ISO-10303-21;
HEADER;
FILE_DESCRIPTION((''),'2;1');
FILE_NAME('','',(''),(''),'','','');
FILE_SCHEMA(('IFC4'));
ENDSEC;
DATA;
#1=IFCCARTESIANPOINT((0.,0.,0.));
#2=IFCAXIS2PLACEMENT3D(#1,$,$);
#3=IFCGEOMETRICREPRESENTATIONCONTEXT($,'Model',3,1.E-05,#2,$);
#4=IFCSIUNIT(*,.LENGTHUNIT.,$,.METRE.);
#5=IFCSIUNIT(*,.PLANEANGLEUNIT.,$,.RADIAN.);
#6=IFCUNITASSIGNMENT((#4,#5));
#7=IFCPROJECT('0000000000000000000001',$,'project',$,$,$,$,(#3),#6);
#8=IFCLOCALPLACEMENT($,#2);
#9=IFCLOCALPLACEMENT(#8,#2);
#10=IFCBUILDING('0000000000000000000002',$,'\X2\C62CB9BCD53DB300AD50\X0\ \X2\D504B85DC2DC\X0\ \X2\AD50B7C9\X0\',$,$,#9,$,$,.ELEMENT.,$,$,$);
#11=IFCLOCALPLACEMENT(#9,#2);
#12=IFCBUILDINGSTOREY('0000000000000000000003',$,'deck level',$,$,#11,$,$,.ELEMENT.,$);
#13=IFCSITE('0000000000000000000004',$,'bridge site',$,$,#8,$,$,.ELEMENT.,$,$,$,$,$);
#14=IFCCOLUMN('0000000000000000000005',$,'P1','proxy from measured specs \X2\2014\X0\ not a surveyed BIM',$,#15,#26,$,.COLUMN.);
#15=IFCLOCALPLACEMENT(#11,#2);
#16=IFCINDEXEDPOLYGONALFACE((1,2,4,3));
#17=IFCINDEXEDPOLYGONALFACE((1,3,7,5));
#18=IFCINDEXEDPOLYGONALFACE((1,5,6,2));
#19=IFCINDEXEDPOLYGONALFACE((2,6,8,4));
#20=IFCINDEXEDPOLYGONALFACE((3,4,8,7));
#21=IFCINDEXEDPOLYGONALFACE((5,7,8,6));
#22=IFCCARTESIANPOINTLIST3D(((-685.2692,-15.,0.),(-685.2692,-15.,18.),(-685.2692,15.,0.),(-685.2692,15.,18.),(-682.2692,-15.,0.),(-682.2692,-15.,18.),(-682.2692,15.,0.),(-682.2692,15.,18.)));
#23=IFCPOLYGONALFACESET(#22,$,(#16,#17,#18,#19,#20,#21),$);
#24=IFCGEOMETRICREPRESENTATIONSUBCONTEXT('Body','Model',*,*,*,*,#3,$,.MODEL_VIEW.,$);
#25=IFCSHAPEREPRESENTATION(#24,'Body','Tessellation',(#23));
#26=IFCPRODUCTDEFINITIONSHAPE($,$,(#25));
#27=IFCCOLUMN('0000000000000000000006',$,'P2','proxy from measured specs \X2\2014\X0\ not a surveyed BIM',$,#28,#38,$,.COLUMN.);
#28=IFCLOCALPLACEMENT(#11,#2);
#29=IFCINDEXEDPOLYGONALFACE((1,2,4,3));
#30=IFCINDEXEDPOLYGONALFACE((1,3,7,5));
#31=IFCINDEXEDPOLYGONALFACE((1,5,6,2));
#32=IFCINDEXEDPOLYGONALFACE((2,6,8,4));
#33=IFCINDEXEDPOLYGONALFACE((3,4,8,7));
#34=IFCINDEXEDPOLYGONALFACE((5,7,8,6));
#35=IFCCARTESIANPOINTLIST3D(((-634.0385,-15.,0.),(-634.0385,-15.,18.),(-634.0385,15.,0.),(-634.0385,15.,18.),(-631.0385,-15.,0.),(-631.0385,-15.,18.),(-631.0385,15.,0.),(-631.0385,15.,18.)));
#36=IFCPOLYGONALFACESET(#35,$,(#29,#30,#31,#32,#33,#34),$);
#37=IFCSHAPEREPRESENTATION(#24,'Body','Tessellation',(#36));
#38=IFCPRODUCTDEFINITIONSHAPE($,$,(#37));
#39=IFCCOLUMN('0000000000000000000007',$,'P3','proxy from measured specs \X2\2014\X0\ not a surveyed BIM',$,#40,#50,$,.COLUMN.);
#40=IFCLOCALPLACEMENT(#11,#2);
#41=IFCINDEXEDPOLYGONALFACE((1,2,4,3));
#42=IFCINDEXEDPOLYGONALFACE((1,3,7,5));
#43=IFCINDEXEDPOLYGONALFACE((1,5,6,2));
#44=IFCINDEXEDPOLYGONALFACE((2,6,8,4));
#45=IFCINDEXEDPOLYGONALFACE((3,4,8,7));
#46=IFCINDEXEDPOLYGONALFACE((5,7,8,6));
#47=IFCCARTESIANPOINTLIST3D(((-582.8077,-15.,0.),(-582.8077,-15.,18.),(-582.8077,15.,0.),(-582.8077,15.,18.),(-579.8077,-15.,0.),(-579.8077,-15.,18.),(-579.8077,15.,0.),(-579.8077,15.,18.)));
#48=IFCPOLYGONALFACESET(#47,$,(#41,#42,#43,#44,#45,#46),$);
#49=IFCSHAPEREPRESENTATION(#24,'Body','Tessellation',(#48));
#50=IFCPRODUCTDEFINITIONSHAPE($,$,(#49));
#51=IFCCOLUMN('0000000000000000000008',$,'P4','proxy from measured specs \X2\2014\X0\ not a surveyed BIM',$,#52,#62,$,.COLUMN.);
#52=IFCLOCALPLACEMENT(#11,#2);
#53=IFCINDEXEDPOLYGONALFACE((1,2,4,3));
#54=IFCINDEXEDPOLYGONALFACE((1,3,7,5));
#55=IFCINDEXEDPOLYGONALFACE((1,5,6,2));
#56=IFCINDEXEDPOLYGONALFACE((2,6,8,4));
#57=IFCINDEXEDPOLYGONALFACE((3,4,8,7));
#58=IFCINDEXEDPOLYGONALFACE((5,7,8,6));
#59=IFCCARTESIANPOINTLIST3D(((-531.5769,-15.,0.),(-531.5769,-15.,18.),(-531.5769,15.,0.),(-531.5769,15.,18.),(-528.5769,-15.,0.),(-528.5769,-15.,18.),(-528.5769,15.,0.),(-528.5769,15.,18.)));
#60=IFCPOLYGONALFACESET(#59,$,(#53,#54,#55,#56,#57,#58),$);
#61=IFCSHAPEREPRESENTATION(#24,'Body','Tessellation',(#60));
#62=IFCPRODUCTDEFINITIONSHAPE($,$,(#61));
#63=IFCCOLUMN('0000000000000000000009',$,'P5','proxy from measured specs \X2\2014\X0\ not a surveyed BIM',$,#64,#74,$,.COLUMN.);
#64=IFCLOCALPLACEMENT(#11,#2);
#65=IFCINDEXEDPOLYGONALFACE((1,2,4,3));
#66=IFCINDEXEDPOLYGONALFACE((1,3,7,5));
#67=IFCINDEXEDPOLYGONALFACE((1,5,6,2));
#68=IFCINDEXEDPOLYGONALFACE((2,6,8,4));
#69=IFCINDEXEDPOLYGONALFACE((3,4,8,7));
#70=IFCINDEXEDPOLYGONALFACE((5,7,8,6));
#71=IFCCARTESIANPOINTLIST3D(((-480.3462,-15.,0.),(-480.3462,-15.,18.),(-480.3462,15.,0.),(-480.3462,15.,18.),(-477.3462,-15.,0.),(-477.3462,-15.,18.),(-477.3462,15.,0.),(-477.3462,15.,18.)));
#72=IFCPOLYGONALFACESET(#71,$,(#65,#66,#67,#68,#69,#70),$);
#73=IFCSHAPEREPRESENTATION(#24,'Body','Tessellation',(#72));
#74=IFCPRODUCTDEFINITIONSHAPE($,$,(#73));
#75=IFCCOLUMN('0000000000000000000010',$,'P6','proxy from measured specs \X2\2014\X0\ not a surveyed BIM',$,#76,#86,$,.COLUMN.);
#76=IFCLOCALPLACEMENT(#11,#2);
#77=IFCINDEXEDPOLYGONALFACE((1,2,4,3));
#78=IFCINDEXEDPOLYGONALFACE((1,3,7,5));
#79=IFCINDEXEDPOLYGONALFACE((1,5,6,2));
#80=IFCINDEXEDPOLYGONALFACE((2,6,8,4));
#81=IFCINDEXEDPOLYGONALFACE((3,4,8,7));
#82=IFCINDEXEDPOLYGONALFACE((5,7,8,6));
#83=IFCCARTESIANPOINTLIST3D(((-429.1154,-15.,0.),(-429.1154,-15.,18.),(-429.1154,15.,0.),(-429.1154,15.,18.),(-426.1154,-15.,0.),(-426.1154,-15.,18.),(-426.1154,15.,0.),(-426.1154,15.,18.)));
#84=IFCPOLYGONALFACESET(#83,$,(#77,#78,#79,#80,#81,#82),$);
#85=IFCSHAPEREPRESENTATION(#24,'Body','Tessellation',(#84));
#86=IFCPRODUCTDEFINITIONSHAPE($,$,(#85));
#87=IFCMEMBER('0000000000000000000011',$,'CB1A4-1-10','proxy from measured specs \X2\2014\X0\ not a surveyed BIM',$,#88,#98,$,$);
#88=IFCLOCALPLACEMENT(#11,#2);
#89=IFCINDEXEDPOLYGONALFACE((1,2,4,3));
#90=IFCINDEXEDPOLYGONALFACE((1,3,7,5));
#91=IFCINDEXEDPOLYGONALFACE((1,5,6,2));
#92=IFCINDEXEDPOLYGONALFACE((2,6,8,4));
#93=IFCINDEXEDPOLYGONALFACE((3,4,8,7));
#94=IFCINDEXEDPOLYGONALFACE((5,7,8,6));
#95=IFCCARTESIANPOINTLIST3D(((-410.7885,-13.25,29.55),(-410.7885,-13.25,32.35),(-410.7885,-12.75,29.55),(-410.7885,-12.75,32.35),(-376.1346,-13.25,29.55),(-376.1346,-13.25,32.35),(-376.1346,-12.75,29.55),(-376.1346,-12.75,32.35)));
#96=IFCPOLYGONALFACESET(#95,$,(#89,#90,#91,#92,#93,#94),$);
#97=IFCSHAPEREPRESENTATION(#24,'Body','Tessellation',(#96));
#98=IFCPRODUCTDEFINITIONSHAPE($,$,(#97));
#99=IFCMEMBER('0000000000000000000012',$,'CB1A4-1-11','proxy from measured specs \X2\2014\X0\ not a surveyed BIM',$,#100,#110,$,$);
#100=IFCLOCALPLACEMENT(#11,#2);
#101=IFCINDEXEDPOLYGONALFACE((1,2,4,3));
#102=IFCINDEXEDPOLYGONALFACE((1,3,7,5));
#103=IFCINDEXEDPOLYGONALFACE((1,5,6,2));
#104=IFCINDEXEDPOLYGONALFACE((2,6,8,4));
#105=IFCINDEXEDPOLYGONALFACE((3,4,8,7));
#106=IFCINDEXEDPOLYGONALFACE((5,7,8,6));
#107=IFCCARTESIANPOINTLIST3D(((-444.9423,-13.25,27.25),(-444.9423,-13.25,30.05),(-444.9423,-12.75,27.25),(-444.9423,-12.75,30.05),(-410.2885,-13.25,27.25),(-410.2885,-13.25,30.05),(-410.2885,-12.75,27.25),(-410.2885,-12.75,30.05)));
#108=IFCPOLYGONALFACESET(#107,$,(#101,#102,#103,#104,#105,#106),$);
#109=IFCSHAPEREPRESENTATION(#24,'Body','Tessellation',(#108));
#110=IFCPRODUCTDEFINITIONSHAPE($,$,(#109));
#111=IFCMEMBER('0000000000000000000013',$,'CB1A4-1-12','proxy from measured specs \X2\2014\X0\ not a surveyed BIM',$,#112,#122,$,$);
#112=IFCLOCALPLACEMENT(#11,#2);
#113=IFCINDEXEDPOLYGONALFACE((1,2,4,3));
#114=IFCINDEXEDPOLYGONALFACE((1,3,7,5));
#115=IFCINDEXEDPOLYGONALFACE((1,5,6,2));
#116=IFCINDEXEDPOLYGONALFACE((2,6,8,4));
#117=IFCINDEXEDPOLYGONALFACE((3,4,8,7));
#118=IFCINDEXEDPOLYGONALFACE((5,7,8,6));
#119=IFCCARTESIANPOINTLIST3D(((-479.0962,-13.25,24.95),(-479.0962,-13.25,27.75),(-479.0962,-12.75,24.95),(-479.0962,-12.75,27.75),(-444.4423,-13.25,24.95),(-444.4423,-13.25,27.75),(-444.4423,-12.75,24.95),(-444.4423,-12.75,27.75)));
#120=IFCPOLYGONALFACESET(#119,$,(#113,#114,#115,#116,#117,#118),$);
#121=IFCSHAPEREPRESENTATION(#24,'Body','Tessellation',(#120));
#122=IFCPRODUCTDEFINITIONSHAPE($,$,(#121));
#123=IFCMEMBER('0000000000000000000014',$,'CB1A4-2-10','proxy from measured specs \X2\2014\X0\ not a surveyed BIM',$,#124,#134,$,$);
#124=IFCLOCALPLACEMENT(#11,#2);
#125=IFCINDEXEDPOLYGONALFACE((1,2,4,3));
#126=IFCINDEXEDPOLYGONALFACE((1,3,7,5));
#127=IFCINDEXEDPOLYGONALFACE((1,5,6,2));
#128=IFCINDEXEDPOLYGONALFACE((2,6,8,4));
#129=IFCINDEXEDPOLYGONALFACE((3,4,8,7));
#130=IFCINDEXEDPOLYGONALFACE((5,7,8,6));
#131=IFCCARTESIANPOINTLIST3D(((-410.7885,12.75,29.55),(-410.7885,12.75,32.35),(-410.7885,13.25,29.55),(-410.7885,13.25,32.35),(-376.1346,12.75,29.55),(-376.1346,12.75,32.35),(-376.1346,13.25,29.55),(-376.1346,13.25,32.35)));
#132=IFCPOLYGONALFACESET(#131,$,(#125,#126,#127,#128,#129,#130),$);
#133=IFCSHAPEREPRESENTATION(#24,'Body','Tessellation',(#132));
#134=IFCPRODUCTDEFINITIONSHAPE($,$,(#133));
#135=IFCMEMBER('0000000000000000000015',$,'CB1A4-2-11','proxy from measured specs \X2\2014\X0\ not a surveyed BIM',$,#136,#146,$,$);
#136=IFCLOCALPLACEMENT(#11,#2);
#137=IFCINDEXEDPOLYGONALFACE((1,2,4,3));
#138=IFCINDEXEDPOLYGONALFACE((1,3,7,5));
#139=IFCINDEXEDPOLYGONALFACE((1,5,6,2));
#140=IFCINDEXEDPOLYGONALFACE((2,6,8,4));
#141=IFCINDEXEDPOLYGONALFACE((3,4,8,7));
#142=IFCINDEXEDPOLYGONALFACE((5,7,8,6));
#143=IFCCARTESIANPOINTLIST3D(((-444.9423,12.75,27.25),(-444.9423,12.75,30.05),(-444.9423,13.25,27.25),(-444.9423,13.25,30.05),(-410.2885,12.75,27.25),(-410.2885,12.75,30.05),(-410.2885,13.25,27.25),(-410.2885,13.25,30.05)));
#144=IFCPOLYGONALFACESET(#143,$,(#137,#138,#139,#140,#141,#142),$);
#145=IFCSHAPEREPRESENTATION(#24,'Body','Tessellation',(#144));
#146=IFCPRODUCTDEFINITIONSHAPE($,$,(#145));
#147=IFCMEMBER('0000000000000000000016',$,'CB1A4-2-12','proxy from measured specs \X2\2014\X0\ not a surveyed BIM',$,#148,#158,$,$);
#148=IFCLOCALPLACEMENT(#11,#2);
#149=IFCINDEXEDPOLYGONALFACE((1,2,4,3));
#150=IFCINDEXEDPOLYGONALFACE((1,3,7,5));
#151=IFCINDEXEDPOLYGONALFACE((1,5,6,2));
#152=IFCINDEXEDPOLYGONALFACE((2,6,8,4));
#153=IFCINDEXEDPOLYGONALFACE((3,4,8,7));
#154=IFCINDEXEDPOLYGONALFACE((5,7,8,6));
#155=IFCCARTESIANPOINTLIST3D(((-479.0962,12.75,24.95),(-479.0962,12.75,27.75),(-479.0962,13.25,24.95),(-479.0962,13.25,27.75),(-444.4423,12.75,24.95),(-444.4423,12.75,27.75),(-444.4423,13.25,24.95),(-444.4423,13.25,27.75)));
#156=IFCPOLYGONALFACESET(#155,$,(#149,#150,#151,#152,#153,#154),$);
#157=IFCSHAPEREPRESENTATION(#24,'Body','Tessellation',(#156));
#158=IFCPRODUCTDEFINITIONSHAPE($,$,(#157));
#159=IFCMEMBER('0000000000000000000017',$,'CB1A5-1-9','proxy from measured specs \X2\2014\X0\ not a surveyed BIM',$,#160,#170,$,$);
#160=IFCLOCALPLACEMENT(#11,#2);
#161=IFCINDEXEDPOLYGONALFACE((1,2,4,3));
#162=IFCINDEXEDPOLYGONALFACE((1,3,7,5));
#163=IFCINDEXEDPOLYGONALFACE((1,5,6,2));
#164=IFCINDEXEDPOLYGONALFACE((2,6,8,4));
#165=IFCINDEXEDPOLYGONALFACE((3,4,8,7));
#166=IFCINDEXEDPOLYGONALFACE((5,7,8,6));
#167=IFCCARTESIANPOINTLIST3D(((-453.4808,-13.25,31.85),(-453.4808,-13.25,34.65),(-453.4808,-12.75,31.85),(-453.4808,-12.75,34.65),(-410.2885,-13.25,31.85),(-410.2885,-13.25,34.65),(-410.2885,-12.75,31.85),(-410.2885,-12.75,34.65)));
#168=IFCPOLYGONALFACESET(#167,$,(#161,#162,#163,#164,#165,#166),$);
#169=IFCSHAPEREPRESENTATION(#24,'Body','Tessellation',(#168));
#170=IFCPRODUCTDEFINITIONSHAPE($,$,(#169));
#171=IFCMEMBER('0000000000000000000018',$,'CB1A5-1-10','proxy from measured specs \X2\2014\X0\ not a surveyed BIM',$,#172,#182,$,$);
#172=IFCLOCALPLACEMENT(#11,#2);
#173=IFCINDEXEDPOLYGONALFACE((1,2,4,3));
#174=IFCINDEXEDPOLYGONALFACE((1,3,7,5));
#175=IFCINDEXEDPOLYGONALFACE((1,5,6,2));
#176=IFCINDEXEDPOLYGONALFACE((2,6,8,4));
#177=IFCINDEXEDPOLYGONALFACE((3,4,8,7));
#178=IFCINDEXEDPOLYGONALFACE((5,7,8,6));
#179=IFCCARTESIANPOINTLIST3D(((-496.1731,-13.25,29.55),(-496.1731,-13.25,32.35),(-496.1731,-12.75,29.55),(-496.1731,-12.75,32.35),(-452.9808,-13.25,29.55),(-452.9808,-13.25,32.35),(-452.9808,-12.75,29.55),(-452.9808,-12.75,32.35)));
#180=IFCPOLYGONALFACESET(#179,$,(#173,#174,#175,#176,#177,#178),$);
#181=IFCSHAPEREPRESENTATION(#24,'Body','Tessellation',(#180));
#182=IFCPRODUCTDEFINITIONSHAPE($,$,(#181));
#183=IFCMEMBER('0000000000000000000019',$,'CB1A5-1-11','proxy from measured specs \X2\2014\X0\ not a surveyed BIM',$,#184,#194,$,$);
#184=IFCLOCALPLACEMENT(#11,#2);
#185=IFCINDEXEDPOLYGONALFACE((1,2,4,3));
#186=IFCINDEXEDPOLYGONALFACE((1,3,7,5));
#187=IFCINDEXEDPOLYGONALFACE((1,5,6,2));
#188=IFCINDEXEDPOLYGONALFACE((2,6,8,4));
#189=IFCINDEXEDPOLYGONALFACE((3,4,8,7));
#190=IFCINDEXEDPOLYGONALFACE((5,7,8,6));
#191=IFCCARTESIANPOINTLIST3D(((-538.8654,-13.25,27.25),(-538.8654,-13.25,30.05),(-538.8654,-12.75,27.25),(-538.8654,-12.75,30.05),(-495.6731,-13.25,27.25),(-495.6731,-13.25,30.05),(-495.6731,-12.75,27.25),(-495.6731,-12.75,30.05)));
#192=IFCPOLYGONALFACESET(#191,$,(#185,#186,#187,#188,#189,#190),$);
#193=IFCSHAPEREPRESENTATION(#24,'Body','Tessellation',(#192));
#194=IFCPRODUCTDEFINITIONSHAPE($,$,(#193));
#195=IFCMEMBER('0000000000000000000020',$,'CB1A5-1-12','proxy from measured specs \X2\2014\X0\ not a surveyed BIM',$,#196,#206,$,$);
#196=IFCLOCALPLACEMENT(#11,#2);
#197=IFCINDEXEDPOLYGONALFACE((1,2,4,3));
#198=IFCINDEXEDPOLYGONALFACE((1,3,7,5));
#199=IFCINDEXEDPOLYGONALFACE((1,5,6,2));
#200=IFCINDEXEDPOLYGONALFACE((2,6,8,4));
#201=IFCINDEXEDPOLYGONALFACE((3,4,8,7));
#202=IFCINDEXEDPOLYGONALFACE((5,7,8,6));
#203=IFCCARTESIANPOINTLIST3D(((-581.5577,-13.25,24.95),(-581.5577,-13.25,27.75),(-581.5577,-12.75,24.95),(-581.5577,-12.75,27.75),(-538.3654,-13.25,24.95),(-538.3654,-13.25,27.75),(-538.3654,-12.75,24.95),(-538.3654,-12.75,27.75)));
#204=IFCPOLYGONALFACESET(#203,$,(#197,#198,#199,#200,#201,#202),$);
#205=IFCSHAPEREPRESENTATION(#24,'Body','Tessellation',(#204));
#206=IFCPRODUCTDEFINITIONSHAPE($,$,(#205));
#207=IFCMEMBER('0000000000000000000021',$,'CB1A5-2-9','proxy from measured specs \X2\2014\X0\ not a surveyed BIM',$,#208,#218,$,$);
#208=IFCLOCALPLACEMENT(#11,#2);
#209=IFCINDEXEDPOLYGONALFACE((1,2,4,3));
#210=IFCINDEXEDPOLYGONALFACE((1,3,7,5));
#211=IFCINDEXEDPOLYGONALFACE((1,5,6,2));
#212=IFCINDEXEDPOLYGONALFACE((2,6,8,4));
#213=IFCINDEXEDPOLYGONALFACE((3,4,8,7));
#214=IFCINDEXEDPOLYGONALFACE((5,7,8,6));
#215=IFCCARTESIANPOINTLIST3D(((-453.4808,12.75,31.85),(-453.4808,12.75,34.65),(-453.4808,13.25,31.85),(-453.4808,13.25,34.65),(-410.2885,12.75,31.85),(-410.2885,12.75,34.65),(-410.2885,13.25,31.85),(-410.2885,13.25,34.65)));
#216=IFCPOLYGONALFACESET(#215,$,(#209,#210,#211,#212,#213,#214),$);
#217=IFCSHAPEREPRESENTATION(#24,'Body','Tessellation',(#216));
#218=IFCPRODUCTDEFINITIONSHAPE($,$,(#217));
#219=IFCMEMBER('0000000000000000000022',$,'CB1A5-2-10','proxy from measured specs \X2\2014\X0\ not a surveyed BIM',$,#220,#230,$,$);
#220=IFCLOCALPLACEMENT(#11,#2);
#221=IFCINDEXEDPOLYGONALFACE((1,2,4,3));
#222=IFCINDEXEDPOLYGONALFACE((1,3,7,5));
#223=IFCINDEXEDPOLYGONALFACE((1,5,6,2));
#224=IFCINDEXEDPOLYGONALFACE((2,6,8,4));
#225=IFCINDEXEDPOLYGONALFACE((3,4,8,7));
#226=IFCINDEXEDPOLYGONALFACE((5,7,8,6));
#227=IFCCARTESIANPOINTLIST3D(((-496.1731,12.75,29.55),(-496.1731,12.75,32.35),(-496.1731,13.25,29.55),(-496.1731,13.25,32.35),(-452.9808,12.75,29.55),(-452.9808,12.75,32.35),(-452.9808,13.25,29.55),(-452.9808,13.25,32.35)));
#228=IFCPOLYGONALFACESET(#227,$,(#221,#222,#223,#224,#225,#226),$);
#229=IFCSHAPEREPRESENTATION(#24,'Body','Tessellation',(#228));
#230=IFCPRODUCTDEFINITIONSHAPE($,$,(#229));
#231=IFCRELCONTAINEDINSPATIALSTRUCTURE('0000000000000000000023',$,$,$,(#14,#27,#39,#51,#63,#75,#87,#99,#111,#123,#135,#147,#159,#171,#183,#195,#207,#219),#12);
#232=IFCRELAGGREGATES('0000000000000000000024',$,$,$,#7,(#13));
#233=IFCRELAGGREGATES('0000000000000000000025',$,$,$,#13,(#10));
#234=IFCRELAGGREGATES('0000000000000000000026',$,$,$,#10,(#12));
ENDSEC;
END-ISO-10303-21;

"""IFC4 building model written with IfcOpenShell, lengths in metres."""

from ifc_helpers import new_model, si_unit, frame, origin, origin_2d, place, context, subcontext, project, spatial, rectangle, extrude, element, save


model = new_model("IFC4")

# Units and contexts
model_context = context("Model", 3, precision=1e-05, world=origin())
body_context = subcontext(model_context, "Body", "Model", "MODEL_VIEW")
ifc_project = project(units=[si_unit("LENGTHUNIT", "METRE"), si_unit("PLANEANGLEUNIT", "RADIAN")], contexts=[model_context])

# Site, building, storey
site_placement = place(None, origin())
site = spatial("IfcSite", under=ifc_project, at=site_placement, Name="bridge site", CompositionType="ELEMENT")
building_placement = place(site_placement, origin())
building = spatial("IfcBuilding", under=site, at=building_placement, Name="올림픽대교 프록시 교량", CompositionType="ELEMENT")
storey_placement = place(building_placement, origin())
storey = spatial("IfcBuildingStorey", under=building, at=storey_placement, Name="deck level", CompositionType="ELEMENT")

# Columns
for number, where, name in (
    (1, (-683.7692, 0.0, 0.0), "P1"),
    (2, (-632.5385, 0.0, 0.0), "P2"),
    (3, (-581.3077, 0.0, 0.0), "P3"),
    (4, (-530.0769, 0.0, 0.0), "P4"),
    (5, (-478.8462, 0.0, 0.0), "P5"),
    (6, (-427.6154, 0.0, 0.0), "P6"),
):
    element("IfcColumn", number, at=place(storey_placement, frame(where)), inside=storey, Name=name, Description="proxy from measured specs — not a surveyed BIM", PredefinedType="COLUMN", context=body_context, shape_type="SweptSolid", body=[
        extrude(rectangle(XDim=3.0, YDim=30.0, at=origin_2d()), origin(), (0.0, 0.0, 1.0), 18.0),
    ])

# Members
member_1_placement = place(storey_placement, frame((-393.4615, -13.0, 29.55)))
element("IfcMember", 7, at=member_1_placement, inside=storey, Name="CB1A4-1-10", Description="proxy from measured specs — not a surveyed BIM", context=body_context, shape_type="SweptSolid", body=[
    extrude(rectangle(XDim=34.6538, YDim=0.5, at=origin_2d()), origin(), (0.0, 0.0, 1.0), 2.8),
])
member_2_placement = place(storey_placement, frame((-427.6154, -13.0, 27.25)))
element("IfcMember", 8, at=member_2_placement, inside=storey, Name="CB1A4-1-11", Description="proxy from measured specs — not a surveyed BIM", context=body_context, shape_type="SweptSolid", body=[
    extrude(rectangle(XDim=34.6538, YDim=0.5, at=origin_2d()), origin(), (0.0, 0.0, 1.0), 2.8),
])
member_3_placement = place(storey_placement, frame((-461.7692, -13.0, 24.95)))
element("IfcMember", 9, at=member_3_placement, inside=storey, Name="CB1A4-1-12", Description="proxy from measured specs — not a surveyed BIM", context=body_context, shape_type="SweptSolid", body=[
    extrude(rectangle(XDim=34.6538, YDim=0.5, at=origin_2d()), origin(), (0.0, 0.0, 1.0), 2.8),
])
member_4_placement = place(storey_placement, frame((-393.4615, 13.0, 29.55)))
element("IfcMember", 10, at=member_4_placement, inside=storey, Name="CB1A4-2-10", Description="proxy from measured specs — not a surveyed BIM", context=body_context, shape_type="SweptSolid", body=[
    extrude(rectangle(XDim=34.6538, YDim=0.5, at=origin_2d()), origin(), (0.0, 0.0, 1.0), 2.8),
])
member_5_placement = place(storey_placement, frame((-427.6154, 13.0, 27.25)))
element("IfcMember", 11, at=member_5_placement, inside=storey, Name="CB1A4-2-11", Description="proxy from measured specs — not a surveyed BIM", context=body_context, shape_type="SweptSolid", body=[
    extrude(rectangle(XDim=34.6538, YDim=0.5, at=origin_2d()), origin(), (0.0, 0.0, 1.0), 2.8),
])
member_6_placement = place(storey_placement, frame((-461.7692, 13.0, 24.95)))
element("IfcMember", 12, at=member_6_placement, inside=storey, Name="CB1A4-2-12", Description="proxy from measured specs — not a surveyed BIM", context=body_context, shape_type="SweptSolid", body=[
    extrude(rectangle(XDim=34.6538, YDim=0.5, at=origin_2d()), origin(), (0.0, 0.0, 1.0), 2.8),
])
member_7_placement = place(storey_placement, frame((-431.8846, -13.0, 31.85)))
element("IfcMember", 13, at=member_7_placement, inside=storey, Name="CB1A5-1-9", Description="proxy from measured specs — not a surveyed BIM", context=body_context, shape_type="SweptSolid", body=[
    extrude(rectangle(XDim=43.1923, YDim=0.5, at=origin_2d()), origin(), (0.0, 0.0, 1.0), 2.8),
])
member_8_placement = place(storey_placement, frame((-474.5769, -13.0, 29.55)))
element("IfcMember", 14, at=member_8_placement, inside=storey, Name="CB1A5-1-10", Description="proxy from measured specs — not a surveyed BIM", context=body_context, shape_type="SweptSolid", body=[
    extrude(rectangle(XDim=43.1923, YDim=0.5, at=origin_2d()), origin(), (0.0, 0.0, 1.0), 2.8),
])
member_9_placement = place(storey_placement, frame((-517.2692, -13.0, 27.25)))
element("IfcMember", 15, at=member_9_placement, inside=storey, Name="CB1A5-1-11", Description="proxy from measured specs — not a surveyed BIM", context=body_context, shape_type="SweptSolid", body=[
    extrude(rectangle(XDim=43.1923, YDim=0.5, at=origin_2d()), origin(), (0.0, 0.0, 1.0), 2.8),
])
member_10_placement = place(storey_placement, frame((-559.9615, -13.0, 24.95)))
element("IfcMember", 16, at=member_10_placement, inside=storey, Name="CB1A5-1-12", Description="proxy from measured specs — not a surveyed BIM", context=body_context, shape_type="SweptSolid", body=[
    extrude(rectangle(XDim=43.1923, YDim=0.5, at=origin_2d()), origin(), (0.0, 0.0, 1.0), 2.8),
])
member_11_placement = place(storey_placement, frame((-431.8846, 13.0, 31.85)))
element("IfcMember", 17, at=member_11_placement, inside=storey, Name="CB1A5-2-9", Description="proxy from measured specs — not a surveyed BIM", context=body_context, shape_type="SweptSolid", body=[
    extrude(rectangle(XDim=43.1923, YDim=0.5, at=origin_2d()), origin(), (0.0, 0.0, 1.0), 2.8),
])
member_12_placement = place(storey_placement, frame((-474.5769, 13.0, 29.55)))
element("IfcMember", 18, at=member_12_placement, inside=storey, Name="CB1A5-2-10", Description="proxy from measured specs — not a surveyed BIM", context=body_context, shape_type="SweptSolid", body=[
    extrude(rectangle(XDim=43.1923, YDim=0.5, at=origin_2d()), origin(), (0.0, 0.0, 1.0), 2.8),
])

save(model, "model.ifc")
